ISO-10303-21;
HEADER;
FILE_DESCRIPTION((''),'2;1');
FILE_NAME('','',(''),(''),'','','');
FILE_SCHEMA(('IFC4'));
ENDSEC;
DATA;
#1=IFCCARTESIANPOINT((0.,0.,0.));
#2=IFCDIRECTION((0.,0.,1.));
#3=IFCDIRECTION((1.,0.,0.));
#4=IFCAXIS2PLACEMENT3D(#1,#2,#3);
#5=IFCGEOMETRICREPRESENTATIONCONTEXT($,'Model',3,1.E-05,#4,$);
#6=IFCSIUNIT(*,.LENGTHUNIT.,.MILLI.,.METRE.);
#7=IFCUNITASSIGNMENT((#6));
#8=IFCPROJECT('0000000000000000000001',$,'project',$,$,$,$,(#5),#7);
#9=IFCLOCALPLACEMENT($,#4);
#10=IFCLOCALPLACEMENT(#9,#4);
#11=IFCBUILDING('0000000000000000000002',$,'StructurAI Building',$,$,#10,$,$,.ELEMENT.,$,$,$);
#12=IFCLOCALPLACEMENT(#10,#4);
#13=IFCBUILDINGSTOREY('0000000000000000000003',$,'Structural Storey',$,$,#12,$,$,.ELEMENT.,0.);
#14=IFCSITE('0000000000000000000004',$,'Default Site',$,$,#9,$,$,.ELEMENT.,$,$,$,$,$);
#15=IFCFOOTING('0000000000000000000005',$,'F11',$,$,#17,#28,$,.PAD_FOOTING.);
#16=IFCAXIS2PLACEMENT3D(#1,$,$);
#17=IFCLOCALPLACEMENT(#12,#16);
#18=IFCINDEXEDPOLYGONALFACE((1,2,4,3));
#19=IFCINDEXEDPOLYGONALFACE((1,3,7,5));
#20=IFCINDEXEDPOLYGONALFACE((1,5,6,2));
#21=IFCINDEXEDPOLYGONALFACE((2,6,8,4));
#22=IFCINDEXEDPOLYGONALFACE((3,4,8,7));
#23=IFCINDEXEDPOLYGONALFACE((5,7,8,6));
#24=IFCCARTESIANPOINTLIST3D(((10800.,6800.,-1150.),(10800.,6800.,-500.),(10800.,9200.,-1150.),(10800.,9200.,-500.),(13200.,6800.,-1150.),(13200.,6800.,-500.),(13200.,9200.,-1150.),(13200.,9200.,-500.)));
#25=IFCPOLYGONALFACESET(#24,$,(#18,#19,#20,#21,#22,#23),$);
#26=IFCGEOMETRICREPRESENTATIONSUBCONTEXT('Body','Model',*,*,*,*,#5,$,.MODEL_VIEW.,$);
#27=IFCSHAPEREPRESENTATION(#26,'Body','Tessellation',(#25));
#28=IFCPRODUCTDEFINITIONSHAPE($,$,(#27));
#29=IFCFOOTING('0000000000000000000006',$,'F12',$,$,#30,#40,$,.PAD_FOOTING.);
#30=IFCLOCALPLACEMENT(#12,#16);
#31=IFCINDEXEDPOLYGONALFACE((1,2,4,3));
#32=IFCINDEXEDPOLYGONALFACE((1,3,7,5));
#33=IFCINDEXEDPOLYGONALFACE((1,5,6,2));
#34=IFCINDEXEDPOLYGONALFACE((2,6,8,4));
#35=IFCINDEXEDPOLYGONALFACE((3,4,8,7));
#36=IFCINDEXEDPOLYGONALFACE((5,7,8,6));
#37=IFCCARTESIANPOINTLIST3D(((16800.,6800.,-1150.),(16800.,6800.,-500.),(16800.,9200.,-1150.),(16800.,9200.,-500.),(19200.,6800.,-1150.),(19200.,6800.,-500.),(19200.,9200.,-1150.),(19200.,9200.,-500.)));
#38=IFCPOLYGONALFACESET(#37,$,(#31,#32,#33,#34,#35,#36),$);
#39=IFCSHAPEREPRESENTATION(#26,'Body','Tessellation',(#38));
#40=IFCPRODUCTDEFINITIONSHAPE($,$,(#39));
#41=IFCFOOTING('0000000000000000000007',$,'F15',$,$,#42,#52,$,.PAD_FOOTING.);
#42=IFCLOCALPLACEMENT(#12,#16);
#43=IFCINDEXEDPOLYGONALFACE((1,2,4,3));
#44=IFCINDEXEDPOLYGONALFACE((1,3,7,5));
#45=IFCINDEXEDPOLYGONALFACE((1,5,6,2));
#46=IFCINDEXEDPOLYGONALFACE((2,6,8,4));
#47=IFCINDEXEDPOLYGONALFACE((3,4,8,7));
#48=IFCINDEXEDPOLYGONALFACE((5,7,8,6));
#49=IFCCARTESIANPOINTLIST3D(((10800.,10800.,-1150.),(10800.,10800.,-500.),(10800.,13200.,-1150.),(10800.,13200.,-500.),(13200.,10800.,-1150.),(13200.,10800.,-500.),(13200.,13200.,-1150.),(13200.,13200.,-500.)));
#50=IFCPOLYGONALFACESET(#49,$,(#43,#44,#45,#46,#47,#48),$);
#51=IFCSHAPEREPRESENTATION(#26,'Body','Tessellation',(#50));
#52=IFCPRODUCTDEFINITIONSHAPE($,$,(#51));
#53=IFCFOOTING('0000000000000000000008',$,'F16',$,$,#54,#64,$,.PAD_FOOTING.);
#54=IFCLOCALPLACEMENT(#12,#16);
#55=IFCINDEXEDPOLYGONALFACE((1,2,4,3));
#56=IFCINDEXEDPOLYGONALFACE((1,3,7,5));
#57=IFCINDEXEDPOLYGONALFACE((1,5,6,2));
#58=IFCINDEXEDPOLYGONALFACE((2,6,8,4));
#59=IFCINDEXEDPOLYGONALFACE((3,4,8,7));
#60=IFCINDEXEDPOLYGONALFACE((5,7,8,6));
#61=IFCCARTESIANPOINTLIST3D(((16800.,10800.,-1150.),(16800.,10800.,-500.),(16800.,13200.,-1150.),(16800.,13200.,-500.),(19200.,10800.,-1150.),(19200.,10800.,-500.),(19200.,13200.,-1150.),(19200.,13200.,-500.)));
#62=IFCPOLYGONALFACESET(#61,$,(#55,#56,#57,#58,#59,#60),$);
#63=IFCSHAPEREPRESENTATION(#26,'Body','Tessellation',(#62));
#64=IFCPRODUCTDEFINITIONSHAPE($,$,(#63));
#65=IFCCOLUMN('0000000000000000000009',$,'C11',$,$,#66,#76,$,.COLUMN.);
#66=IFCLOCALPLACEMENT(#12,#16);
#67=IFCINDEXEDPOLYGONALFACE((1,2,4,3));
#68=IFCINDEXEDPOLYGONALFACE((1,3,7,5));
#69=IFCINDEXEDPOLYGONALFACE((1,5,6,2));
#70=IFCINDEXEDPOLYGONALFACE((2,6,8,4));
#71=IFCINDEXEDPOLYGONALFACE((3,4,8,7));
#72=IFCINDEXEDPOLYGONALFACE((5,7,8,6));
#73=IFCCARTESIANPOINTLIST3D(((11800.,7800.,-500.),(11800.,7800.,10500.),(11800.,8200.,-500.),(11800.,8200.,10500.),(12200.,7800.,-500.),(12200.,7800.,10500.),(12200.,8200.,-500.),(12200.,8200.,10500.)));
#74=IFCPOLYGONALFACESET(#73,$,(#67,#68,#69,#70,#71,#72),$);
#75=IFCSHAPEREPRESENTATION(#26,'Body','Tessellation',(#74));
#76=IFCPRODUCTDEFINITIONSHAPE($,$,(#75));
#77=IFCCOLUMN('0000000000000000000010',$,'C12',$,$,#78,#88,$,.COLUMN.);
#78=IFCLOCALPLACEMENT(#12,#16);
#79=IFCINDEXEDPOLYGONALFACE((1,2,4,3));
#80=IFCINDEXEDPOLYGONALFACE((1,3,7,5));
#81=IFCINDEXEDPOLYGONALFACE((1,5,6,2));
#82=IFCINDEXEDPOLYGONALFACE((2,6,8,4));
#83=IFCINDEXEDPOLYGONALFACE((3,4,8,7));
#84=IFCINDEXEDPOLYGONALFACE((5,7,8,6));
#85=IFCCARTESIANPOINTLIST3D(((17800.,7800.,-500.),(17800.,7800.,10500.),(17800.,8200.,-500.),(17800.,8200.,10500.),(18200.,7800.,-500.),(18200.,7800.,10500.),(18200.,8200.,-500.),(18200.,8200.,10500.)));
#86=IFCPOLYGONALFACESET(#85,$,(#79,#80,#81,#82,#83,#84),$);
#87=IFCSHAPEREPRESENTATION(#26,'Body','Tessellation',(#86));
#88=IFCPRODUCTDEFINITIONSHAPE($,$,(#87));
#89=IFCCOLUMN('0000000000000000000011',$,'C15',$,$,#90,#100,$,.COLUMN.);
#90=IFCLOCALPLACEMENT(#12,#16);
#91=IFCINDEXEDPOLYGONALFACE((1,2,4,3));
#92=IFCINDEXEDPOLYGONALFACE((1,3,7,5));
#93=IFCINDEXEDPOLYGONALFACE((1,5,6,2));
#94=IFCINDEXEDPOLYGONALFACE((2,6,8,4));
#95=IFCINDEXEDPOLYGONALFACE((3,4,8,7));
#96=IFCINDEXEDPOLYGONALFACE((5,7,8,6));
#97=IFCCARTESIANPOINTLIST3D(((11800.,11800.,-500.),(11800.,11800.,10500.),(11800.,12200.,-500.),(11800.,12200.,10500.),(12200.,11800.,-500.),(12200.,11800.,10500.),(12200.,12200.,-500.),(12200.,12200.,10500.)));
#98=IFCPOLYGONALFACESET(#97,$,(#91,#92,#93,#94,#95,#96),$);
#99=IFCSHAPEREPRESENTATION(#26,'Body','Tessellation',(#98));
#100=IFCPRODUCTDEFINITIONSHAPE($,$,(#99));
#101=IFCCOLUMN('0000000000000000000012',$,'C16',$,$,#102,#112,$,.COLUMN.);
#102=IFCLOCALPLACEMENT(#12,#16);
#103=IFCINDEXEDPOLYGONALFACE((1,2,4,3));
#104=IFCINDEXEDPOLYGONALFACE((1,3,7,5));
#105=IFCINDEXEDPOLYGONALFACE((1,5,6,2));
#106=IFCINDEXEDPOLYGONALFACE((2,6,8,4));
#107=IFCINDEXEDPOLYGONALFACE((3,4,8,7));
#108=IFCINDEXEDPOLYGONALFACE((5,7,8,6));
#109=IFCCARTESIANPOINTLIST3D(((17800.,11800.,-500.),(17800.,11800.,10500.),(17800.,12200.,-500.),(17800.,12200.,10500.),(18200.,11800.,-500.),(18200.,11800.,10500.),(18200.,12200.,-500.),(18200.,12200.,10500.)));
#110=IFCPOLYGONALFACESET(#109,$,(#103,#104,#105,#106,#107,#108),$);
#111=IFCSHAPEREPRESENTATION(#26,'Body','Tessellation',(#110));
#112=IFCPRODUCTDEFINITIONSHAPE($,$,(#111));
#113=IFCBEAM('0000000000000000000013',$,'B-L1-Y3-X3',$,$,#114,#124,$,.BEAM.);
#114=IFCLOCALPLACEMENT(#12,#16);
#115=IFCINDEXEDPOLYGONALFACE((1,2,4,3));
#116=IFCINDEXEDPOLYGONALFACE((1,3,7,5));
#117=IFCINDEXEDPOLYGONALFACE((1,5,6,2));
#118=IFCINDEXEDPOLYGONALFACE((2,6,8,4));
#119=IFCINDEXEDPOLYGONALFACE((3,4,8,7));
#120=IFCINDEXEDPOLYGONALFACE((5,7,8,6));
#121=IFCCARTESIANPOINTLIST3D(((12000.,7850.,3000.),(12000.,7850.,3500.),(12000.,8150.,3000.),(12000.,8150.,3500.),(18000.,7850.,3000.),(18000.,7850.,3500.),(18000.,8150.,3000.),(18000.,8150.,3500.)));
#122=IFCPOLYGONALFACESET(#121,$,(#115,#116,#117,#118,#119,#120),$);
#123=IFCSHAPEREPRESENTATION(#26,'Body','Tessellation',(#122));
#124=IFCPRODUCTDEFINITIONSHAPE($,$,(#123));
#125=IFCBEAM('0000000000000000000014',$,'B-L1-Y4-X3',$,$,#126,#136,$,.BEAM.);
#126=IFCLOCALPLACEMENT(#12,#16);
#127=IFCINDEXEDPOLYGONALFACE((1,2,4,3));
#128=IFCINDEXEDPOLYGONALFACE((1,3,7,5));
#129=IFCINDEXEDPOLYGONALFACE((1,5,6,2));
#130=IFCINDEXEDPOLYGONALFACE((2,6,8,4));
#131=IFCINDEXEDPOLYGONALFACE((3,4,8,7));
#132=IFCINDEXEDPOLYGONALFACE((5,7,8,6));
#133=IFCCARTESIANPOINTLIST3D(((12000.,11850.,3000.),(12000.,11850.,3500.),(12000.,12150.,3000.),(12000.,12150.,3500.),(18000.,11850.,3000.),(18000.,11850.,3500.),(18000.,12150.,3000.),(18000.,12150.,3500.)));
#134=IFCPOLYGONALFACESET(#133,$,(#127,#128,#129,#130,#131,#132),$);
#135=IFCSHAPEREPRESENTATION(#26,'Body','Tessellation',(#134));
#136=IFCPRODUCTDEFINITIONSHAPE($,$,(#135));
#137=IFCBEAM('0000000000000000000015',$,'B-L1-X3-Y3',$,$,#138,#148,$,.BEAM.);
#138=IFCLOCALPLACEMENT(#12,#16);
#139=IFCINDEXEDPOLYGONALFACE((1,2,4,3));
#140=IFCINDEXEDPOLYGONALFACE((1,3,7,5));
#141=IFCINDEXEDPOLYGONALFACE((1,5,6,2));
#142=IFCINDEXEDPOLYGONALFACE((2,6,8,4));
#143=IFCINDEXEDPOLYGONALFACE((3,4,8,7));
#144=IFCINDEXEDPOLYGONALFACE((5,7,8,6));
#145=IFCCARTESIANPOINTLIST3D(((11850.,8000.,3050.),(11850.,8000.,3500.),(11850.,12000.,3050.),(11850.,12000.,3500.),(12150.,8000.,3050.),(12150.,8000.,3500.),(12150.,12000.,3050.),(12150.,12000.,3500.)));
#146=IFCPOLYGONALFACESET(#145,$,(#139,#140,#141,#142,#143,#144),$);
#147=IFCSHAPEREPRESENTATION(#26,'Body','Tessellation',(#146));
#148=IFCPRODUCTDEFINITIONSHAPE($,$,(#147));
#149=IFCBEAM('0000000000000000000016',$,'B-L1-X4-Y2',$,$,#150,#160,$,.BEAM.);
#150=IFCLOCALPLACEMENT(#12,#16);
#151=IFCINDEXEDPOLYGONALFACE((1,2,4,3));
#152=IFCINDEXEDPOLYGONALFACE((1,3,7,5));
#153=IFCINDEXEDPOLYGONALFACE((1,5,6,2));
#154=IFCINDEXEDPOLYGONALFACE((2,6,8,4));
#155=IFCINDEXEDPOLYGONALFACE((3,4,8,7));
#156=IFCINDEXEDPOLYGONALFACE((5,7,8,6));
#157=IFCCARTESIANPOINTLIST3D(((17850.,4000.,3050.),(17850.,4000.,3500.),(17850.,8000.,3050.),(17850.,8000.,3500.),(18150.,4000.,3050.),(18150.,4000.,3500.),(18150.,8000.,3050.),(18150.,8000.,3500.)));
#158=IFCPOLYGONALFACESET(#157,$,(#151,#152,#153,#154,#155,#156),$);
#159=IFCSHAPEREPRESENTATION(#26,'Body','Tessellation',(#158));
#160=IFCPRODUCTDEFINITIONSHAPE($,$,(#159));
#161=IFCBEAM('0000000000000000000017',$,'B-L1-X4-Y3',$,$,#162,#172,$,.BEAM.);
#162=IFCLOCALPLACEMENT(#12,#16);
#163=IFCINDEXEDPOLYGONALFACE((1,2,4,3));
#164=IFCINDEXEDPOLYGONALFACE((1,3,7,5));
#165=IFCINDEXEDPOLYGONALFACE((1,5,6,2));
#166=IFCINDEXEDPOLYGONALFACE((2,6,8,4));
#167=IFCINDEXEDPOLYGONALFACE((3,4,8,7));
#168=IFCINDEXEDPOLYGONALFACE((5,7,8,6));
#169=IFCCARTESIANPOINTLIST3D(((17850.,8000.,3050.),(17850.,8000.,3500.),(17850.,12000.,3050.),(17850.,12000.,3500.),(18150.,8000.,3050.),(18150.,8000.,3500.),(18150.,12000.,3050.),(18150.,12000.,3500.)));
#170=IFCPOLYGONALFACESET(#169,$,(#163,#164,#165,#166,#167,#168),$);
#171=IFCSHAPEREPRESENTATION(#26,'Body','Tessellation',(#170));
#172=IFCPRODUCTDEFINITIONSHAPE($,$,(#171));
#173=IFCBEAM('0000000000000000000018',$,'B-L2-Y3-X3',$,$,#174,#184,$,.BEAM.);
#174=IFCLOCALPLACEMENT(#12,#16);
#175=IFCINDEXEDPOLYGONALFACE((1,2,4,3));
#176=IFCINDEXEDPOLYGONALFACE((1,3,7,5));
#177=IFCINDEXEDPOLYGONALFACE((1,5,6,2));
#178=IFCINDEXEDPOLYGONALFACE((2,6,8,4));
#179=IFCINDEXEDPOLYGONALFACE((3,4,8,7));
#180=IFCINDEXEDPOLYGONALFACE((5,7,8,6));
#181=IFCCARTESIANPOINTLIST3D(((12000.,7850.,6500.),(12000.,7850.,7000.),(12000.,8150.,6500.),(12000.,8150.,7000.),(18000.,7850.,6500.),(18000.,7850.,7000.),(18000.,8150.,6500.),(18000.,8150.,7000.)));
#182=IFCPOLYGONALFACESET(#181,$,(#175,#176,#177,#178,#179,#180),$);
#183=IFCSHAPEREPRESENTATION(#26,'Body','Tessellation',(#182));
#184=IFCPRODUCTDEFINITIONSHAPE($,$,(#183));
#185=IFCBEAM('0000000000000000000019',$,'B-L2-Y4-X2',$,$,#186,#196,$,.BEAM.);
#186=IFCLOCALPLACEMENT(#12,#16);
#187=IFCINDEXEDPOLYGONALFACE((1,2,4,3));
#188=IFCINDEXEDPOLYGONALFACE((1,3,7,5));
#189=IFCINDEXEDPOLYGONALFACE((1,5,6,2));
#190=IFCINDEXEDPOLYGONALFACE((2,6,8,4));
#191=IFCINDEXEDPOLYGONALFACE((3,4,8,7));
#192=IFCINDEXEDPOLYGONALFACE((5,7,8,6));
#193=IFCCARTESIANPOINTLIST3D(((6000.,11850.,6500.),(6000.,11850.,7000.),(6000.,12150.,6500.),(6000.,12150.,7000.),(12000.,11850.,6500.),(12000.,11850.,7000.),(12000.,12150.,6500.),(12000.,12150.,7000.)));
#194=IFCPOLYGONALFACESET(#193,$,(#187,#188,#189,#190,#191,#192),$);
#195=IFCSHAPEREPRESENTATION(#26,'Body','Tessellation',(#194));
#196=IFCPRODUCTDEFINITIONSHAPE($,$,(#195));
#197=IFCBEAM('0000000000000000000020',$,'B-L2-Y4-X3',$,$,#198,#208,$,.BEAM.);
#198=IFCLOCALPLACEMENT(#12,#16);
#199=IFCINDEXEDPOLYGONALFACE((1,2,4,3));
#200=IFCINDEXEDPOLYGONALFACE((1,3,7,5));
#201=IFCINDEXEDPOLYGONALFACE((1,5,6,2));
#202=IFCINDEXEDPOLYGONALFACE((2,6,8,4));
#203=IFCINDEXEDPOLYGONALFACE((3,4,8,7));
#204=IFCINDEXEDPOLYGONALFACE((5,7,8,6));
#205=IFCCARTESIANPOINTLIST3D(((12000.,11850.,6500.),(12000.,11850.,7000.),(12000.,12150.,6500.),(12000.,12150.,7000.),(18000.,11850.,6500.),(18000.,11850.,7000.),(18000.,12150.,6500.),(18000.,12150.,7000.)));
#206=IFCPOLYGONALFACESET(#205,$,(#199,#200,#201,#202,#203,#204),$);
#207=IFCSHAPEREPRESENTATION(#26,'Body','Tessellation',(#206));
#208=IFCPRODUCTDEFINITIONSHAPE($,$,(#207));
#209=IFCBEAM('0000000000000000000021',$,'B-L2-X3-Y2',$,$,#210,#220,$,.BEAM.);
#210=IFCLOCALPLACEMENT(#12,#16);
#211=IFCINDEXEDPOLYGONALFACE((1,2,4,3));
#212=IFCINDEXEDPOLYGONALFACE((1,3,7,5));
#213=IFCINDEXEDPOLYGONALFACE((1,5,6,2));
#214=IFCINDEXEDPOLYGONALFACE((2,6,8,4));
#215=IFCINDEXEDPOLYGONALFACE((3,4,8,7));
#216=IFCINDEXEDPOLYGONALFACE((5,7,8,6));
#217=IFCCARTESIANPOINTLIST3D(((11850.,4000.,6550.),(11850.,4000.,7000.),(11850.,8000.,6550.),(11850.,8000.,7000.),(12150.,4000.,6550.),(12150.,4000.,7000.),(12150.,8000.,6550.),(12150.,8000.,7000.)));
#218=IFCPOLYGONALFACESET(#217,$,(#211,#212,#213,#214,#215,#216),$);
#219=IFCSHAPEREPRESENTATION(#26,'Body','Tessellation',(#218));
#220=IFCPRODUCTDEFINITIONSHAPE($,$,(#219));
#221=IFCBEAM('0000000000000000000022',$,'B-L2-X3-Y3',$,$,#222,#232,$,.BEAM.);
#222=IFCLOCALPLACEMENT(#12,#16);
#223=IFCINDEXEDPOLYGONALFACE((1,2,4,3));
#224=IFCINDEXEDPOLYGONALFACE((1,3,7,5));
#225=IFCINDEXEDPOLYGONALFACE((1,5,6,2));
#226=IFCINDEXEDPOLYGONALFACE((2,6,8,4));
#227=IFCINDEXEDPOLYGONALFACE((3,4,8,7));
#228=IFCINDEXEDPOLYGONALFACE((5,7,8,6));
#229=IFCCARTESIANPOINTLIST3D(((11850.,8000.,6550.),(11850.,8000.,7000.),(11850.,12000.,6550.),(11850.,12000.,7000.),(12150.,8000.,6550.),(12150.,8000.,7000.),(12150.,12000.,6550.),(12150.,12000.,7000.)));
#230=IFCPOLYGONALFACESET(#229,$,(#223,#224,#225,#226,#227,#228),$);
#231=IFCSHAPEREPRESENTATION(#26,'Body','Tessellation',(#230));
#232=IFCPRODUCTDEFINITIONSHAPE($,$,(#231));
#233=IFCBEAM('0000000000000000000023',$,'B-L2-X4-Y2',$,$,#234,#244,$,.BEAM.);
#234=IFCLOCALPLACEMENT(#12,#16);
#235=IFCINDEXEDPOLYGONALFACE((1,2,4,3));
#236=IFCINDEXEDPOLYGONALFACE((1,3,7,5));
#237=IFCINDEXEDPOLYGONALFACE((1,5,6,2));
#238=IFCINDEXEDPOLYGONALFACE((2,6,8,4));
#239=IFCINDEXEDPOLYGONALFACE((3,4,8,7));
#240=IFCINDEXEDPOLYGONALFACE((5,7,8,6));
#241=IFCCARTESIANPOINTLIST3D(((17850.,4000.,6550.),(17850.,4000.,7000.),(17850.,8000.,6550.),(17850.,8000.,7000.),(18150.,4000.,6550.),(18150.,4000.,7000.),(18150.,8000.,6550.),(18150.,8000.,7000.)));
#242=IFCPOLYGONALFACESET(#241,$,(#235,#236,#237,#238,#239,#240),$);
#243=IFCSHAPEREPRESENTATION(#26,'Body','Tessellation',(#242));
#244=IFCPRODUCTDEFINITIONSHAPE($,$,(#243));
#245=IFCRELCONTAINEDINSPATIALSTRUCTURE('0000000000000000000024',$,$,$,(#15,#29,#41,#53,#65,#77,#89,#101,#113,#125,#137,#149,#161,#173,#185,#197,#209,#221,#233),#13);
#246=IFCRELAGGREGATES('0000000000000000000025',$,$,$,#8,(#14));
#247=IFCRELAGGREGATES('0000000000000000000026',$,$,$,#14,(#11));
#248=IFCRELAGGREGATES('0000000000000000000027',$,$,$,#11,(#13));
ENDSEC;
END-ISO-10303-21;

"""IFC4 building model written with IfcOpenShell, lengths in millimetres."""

from ifc_helpers import new_model, si_unit, frame, origin_with_axes, place, context, subcontext, project, spatial, rectangle, extrude, element, save


model = new_model("IFC4")

# Units and contexts
model_context = context("Model", 3, precision=1e-05, world=origin_with_axes())
body_context = subcontext(model_context, "Body", "Model", "MODEL_VIEW")
ifc_project = project(units=[si_unit("LENGTHUNIT", "METRE", prefix="MILLI")], contexts=[model_context])

# Site, building, storey
site_placement = place(None, origin_with_axes())
site = spatial("IfcSite", under=ifc_project, at=site_placement, Name="Default Site", CompositionType="ELEMENT")
building_placement = place(site_placement, origin_with_axes())
building = spatial("IfcBuilding", under=site, at=building_placement, Name="StructurAI Building", CompositionType="ELEMENT")
storey_placement = place(building_placement, origin_with_axes())
storey = spatial("IfcBuildingStorey", under=building, at=storey_placement, Name="Structural Storey", CompositionType="ELEMENT", Elevation=0.0)

# Footings
for number, where, z_axis, x_axis, name in (
    (1, (12000.0, 8000.0, -1150.0), (0.0, 0.0, 1.0), (1.0, 0.0, 0.0), "F11"),
    (2, (18000.0, 8000.0, -1150.0), (0.0, 0.0, 1.0), (1.0, 0.0, 0.0), "F12"),
    (3, (12000.0, 12000.0, -1150.0), (0.0, 0.0, 1.0), (1.0, 0.0, 0.0), "F15"),
    (4, (18000.0, 12000.0, -1150.0), (0.0, 0.0, 1.0), (1.0, 0.0, 0.0), "F16"),
):
    element("IfcFooting", number, at=place(storey_placement, frame(where, z_axis=z_axis, x_axis=x_axis)), inside=storey, Name=name, PredefinedType="PAD_FOOTING", context=body_context, shape_type="SweptSolid", body=[
        extrude(rectangle(XDim=2400.0, YDim=2400.0), origin_with_axes(), (0.0, 0.0, 1.0), 650.0),
    ])

# Columns
for number, where, z_axis, x_axis, name in (
    (5, (12000.0, 8000.0, -500.0), (0.0, 0.0, 1.0), (1.0, 0.0, 0.0), "C11"),
    (6, (18000.0, 8000.0, -500.0), (0.0, 0.0, 1.0), (1.0, 0.0, 0.0), "C12"),
    (7, (12000.0, 12000.0, -500.0), (0.0, 0.0, 1.0), (1.0, 0.0, 0.0), "C15"),
    (8, (18000.0, 12000.0, -500.0), (0.0, 0.0, 1.0), (1.0, 0.0, 0.0), "C16"),
):
    element("IfcColumn", number, at=place(storey_placement, frame(where, z_axis=z_axis, x_axis=x_axis)), inside=storey, Name=name, PredefinedType="COLUMN", context=body_context, shape_type="SweptSolid", body=[
        extrude(rectangle(XDim=400.0, YDim=400.0), origin_with_axes(), (0.0, 0.0, 1.0), 11000.0),
    ])

# Beams
for number, where, z_axis, x_axis, name in (
    (9, (15000.0, 8000.0, 3000.0), (0.0, 0.0, 1.0), (1.0, 0.0, 0.0), "B-L1-Y3-X3"),
    (10, (15000.0, 12000.0, 3000.0), (0.0, 0.0, 1.0), (1.0, 0.0, 0.0), "B-L1-Y4-X3"),
):
    element("IfcBeam", number, at=place(storey_placement, frame(where, z_axis=z_axis, x_axis=x_axis)), inside=storey, Name=name, PredefinedType="BEAM", context=body_context, shape_type="SweptSolid", body=[
        extrude(rectangle(XDim=6000.0, YDim=300.0), origin_with_axes(), (0.0, 0.0, 1.0), 500.0),
    ])
for number, where, z_axis, x_axis, name in (
    (11, (12000.0, 10000.0, 3050.0), (0.0, 0.0, 1.0), (0.0, 1.0, 0.0), "B-L1-X3-Y3"),
    (12, (18000.0, 6000.0, 3050.0), (0.0, 0.0, 1.0), (0.0, 1.0, 0.0), "B-L1-X4-Y2"),
    (13, (18000.0, 10000.0, 3050.0), (0.0, 0.0, 1.0), (0.0, 1.0, 0.0), "B-L1-X4-Y3"),
):
    element("IfcBeam", number, at=place(storey_placement, frame(where, z_axis=z_axis, x_axis=x_axis)), inside=storey, Name=name, PredefinedType="BEAM", context=body_context, shape_type="SweptSolid", body=[
        extrude(rectangle(XDim=4000.0, YDim=300.0), origin_with_axes(), (0.0, 0.0, 1.0), 450.0),
    ])
for number, where, z_axis, x_axis, name in (
    (14, (15000.0, 8000.0, 6500.0), (0.0, 0.0, 1.0), (1.0, 0.0, 0.0), "B-L2-Y3-X3"),
    (15, (9000.0, 12000.0, 6500.0), (0.0, 0.0, 1.0), (1.0, 0.0, 0.0), "B-L2-Y4-X2"),
    (16, (15000.0, 12000.0, 6500.0), (0.0, 0.0, 1.0), (1.0, 0.0, 0.0), "B-L2-Y4-X3"),
):
    element("IfcBeam", number, at=place(storey_placement, frame(where, z_axis=z_axis, x_axis=x_axis)), inside=storey, Name=name, PredefinedType="BEAM", context=body_context, shape_type="SweptSolid", body=[
        extrude(rectangle(XDim=6000.0, YDim=300.0), origin_with_axes(), (0.0, 0.0, 1.0), 500.0),
    ])
for number, where, z_axis, x_axis, name in (
    (17, (12000.0, 6000.0, 6550.0), (0.0, 0.0, 1.0), (0.0, 1.0, 0.0), "B-L2-X3-Y2"),
    (18, (12000.0, 10000.0, 6550.0), (0.0, 0.0, 1.0), (0.0, 1.0, 0.0), "B-L2-X3-Y3"),
    (19, (18000.0, 6000.0, 6550.0), (0.0, 0.0, 1.0), (0.0, 1.0, 0.0), "B-L2-X4-Y2"),
):
    element("IfcBeam", number, at=place(storey_placement, frame(where, z_axis=z_axis, x_axis=x_axis)), inside=storey, Name=name, PredefinedType="BEAM", context=body_context, shape_type="SweptSolid", body=[
        extrude(rectangle(XDim=4000.0, YDim=300.0), origin_with_axes(), (0.0, 0.0, 1.0), 450.0),
    ])

save(model, "model.ifc")
